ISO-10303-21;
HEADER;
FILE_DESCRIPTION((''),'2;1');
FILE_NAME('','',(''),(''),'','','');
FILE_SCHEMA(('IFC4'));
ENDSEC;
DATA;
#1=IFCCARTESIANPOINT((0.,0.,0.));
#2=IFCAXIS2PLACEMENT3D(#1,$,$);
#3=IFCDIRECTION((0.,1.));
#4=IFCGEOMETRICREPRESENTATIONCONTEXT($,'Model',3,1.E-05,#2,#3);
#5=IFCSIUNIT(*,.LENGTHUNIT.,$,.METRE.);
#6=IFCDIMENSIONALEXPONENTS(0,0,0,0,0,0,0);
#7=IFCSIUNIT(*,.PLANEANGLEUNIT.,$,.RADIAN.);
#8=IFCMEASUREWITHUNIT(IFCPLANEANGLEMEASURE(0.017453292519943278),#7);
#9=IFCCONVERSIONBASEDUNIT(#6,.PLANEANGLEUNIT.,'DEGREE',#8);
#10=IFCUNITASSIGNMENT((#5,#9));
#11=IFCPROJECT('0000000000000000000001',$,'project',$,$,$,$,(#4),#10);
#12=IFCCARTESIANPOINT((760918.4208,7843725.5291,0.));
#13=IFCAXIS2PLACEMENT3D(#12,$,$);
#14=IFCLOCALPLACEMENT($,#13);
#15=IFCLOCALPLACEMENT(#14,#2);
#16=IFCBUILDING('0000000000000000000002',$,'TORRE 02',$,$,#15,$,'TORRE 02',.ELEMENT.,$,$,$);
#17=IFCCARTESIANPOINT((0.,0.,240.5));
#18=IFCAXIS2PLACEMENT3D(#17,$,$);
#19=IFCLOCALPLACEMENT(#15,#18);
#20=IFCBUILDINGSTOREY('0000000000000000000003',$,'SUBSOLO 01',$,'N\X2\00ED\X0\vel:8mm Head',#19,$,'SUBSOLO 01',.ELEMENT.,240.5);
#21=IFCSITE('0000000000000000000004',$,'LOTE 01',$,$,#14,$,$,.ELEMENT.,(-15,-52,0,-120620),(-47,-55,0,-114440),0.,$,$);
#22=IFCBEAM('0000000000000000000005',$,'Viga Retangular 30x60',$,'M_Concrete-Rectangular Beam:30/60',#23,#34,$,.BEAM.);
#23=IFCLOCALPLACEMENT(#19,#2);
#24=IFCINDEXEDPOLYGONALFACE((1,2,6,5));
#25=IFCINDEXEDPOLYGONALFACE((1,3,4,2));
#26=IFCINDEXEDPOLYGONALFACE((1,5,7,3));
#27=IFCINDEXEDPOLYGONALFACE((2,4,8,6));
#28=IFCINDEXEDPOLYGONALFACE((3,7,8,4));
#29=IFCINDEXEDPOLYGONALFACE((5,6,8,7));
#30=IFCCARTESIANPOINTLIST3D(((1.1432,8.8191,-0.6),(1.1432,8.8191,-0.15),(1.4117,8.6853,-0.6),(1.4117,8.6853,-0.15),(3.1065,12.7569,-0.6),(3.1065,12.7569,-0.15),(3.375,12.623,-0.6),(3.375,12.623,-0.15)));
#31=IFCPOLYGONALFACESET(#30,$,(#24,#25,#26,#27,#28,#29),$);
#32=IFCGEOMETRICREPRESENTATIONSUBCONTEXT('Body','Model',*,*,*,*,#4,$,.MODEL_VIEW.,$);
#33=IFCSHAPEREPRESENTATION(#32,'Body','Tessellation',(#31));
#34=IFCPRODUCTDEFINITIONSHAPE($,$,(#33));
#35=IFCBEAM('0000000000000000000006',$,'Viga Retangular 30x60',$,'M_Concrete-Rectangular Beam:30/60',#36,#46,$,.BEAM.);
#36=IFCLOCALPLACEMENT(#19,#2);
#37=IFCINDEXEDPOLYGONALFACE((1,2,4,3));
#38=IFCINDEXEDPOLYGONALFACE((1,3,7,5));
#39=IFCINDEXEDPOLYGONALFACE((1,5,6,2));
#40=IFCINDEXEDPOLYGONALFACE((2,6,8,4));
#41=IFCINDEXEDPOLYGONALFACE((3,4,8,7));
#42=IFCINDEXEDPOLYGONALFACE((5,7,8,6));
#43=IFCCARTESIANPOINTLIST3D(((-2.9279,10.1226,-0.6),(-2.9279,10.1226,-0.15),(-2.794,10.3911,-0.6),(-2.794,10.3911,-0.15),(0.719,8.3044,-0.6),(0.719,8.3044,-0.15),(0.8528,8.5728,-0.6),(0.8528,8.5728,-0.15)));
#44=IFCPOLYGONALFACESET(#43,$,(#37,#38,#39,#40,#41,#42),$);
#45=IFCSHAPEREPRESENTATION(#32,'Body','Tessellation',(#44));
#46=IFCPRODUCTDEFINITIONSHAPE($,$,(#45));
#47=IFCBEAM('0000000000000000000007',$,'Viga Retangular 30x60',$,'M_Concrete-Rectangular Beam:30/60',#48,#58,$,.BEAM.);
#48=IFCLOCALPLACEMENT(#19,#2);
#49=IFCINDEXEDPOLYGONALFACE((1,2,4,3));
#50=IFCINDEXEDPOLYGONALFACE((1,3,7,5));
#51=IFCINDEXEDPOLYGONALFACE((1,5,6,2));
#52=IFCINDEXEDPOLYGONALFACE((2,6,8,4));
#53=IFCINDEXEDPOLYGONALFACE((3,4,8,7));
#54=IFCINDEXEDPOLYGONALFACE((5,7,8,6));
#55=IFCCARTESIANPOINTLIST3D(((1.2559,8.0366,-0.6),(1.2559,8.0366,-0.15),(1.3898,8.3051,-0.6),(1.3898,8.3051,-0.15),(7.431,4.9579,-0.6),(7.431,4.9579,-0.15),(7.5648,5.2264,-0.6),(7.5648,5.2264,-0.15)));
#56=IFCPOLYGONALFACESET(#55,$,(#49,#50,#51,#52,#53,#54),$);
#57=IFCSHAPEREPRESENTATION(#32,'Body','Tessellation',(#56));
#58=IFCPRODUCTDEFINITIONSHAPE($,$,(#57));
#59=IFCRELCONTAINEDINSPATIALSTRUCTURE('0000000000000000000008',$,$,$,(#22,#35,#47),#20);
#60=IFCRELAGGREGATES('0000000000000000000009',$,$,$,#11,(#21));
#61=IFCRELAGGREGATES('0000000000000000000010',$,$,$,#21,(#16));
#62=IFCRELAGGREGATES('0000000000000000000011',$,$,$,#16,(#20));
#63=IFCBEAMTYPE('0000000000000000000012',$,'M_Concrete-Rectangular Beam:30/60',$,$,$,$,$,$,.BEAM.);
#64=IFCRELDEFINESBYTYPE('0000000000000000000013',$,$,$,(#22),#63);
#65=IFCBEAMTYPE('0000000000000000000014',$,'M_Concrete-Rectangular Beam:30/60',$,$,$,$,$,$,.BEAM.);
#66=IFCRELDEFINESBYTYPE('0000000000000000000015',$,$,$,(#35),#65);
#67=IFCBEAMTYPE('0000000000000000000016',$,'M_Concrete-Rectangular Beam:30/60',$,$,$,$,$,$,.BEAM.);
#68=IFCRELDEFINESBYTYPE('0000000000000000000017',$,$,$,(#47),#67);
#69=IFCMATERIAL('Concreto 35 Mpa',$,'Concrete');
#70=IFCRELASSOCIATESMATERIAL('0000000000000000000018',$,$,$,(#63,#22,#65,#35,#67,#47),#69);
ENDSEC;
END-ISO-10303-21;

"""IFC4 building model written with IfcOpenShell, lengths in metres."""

from ifc_helpers import new_model, entity, si_unit, converted_unit, direction, frame, origin, place, context, subcontext, project, spatial, indexed_curve, outline, extrude, source, transform, mapped, material, type_object, type_shapes, element, save


model = new_model("IFC4")

# Units and contexts
model_context = context("Model", 3, precision=1e-05, world=origin(), true_north=direction((0.0, 1.0)))
body_context = subcontext(model_context, "Body", "Model", "MODEL_VIEW")
ifc_project = project(units=[si_unit("LENGTHUNIT", "METRE"), converted_unit("PLANEANGLEUNIT", "DEGREE", entity("IfcPlaneAngleMeasure", 0.017453292519943278), si_unit("PLANEANGLEUNIT", "RADIAN"), dimensions=[0, 0, 0, 0, 0, 0, 0])], contexts=[model_context])

# Site, building, storey
site_placement = place(None, frame((760918.4208, 7843725.5291, 0.0)))
site = spatial("IfcSite", under=ifc_project, at=site_placement, Name="LOTE 01", CompositionType="ELEMENT", RefLatitude=(-15, -52, 0, -120620), RefLongitude=(-47, -55, 0, -114440), RefElevation=0.0)
building_placement = place(site_placement, origin())
building = spatial("IfcBuilding", under=site, at=building_placement, Name="TORRE 02", LongName="TORRE 02", CompositionType="ELEMENT")
storey_placement = place(building_placement, frame((0.0, 0.0, 240.5)))
storey = spatial("IfcBuildingStorey", under=building, at=storey_placement, Name="SUBSOLO 01", ObjectType="Nível:8mm Head", LongName="SUBSOLO 01", CompositionType="ELEMENT", Elevation=240.5)

# Shared definitions
ifc_material = material(Name="Concreto 35 Mpa", Category="Concrete")

# Beams
beam_type_1 = type_object("IfcBeamType", Name="M_Concrete-Rectangular Beam:30/60", PredefinedType="BEAM", material=ifc_material)
shared_shape_1 = source(origin(), body_context, "Body", "SweptSolid", [
    extrude(outline(indexed_curve([(-0.225, -0.15), (0.225, -0.15), (0.225, 0.15), (-0.225, 0.15), (-0.225, -0.15)], self_intersect=False)), frame((1.2775, 8.7522, 240.125), z_axis=(0.446198, 0.894934, 0.0), x_axis=(0.0, 0.0, 1.0)), (0.0, 0.0, 1.0), 4.4),
])
type_shapes(beam_type_1, [shared_shape_1])
beam_1_placement = place(storey_placement, frame((0.0, 0.0, -240.5)))
element("IfcBeam", 1, at=beam_1_placement, inside=storey, type_object=beam_type_1, material=ifc_material, Name="Viga Retangular 30x60", ObjectType="M_Concrete-Rectangular Beam:30/60", PredefinedType="BEAM", context=body_context, shape_type="MappedRepresentation", body=[
    mapped(shared_shape_1, transform((0.0, 0.0, 0.0), scale=1.0)),
])
beam_type_2 = type_object("IfcBeamType", Name="M_Concrete-Rectangular Beam:30/60", PredefinedType="BEAM", material=ifc_material)
shared_shape_2 = source(origin(), body_context, "Body", "SweptSolid", [
    extrude(outline(indexed_curve([(-0.225, -0.15), (0.225, -0.15), (0.225, 0.15), (-0.225, 0.15), (-0.225, -0.15)], self_intersect=False)), frame((-2.861, 10.2569, 240.125), z_axis=(0.894934, -0.446198, 0.0), x_axis=(0.0, 0.0, -1.0)), (0.0, 0.0, 1.0), 4.075),
])
type_shapes(beam_type_2, [shared_shape_2])
beam_2_placement = place(storey_placement, frame((0.0, 0.0, -240.5)))
element("IfcBeam", 2, at=beam_2_placement, inside=storey, type_object=beam_type_2, material=ifc_material, Name="Viga Retangular 30x60", ObjectType="M_Concrete-Rectangular Beam:30/60", PredefinedType="BEAM", context=body_context, shape_type="MappedRepresentation", body=[
    mapped(shared_shape_2, transform((0.0, 0.0, 0.0), scale=1.0)),
])
beam_type_3 = type_object("IfcBeamType", Name="M_Concrete-Rectangular Beam:30/60", PredefinedType="BEAM", material=ifc_material)
shared_shape_3 = source(origin(), body_context, "Body", "SweptSolid", [
    extrude(outline(indexed_curve([(-0.225, -0.15), (0.225, -0.15), (0.225, 0.15), (-0.225, 0.15), (-0.225, -0.15)], self_intersect=False)), frame((1.3228, 8.1709, 240.125), z_axis=(0.894934, -0.446198, 0.0), x_axis=(0.0, 0.0, -1.0)), (0.0, 0.0, 1.0), 6.9),
])
type_shapes(beam_type_3, [shared_shape_3])
beam_3_placement = place(storey_placement, frame((0.0, 0.0, -240.5)))
element("IfcBeam", 3, at=beam_3_placement, inside=storey, type_object=beam_type_3, material=ifc_material, Name="Viga Retangular 30x60", ObjectType="M_Concrete-Rectangular Beam:30/60", PredefinedType="BEAM", context=body_context, shape_type="MappedRepresentation", body=[
    mapped(shared_shape_3, transform((0.0, 0.0, 0.0), scale=1.0)),
])

save(model, "model.ifc")
